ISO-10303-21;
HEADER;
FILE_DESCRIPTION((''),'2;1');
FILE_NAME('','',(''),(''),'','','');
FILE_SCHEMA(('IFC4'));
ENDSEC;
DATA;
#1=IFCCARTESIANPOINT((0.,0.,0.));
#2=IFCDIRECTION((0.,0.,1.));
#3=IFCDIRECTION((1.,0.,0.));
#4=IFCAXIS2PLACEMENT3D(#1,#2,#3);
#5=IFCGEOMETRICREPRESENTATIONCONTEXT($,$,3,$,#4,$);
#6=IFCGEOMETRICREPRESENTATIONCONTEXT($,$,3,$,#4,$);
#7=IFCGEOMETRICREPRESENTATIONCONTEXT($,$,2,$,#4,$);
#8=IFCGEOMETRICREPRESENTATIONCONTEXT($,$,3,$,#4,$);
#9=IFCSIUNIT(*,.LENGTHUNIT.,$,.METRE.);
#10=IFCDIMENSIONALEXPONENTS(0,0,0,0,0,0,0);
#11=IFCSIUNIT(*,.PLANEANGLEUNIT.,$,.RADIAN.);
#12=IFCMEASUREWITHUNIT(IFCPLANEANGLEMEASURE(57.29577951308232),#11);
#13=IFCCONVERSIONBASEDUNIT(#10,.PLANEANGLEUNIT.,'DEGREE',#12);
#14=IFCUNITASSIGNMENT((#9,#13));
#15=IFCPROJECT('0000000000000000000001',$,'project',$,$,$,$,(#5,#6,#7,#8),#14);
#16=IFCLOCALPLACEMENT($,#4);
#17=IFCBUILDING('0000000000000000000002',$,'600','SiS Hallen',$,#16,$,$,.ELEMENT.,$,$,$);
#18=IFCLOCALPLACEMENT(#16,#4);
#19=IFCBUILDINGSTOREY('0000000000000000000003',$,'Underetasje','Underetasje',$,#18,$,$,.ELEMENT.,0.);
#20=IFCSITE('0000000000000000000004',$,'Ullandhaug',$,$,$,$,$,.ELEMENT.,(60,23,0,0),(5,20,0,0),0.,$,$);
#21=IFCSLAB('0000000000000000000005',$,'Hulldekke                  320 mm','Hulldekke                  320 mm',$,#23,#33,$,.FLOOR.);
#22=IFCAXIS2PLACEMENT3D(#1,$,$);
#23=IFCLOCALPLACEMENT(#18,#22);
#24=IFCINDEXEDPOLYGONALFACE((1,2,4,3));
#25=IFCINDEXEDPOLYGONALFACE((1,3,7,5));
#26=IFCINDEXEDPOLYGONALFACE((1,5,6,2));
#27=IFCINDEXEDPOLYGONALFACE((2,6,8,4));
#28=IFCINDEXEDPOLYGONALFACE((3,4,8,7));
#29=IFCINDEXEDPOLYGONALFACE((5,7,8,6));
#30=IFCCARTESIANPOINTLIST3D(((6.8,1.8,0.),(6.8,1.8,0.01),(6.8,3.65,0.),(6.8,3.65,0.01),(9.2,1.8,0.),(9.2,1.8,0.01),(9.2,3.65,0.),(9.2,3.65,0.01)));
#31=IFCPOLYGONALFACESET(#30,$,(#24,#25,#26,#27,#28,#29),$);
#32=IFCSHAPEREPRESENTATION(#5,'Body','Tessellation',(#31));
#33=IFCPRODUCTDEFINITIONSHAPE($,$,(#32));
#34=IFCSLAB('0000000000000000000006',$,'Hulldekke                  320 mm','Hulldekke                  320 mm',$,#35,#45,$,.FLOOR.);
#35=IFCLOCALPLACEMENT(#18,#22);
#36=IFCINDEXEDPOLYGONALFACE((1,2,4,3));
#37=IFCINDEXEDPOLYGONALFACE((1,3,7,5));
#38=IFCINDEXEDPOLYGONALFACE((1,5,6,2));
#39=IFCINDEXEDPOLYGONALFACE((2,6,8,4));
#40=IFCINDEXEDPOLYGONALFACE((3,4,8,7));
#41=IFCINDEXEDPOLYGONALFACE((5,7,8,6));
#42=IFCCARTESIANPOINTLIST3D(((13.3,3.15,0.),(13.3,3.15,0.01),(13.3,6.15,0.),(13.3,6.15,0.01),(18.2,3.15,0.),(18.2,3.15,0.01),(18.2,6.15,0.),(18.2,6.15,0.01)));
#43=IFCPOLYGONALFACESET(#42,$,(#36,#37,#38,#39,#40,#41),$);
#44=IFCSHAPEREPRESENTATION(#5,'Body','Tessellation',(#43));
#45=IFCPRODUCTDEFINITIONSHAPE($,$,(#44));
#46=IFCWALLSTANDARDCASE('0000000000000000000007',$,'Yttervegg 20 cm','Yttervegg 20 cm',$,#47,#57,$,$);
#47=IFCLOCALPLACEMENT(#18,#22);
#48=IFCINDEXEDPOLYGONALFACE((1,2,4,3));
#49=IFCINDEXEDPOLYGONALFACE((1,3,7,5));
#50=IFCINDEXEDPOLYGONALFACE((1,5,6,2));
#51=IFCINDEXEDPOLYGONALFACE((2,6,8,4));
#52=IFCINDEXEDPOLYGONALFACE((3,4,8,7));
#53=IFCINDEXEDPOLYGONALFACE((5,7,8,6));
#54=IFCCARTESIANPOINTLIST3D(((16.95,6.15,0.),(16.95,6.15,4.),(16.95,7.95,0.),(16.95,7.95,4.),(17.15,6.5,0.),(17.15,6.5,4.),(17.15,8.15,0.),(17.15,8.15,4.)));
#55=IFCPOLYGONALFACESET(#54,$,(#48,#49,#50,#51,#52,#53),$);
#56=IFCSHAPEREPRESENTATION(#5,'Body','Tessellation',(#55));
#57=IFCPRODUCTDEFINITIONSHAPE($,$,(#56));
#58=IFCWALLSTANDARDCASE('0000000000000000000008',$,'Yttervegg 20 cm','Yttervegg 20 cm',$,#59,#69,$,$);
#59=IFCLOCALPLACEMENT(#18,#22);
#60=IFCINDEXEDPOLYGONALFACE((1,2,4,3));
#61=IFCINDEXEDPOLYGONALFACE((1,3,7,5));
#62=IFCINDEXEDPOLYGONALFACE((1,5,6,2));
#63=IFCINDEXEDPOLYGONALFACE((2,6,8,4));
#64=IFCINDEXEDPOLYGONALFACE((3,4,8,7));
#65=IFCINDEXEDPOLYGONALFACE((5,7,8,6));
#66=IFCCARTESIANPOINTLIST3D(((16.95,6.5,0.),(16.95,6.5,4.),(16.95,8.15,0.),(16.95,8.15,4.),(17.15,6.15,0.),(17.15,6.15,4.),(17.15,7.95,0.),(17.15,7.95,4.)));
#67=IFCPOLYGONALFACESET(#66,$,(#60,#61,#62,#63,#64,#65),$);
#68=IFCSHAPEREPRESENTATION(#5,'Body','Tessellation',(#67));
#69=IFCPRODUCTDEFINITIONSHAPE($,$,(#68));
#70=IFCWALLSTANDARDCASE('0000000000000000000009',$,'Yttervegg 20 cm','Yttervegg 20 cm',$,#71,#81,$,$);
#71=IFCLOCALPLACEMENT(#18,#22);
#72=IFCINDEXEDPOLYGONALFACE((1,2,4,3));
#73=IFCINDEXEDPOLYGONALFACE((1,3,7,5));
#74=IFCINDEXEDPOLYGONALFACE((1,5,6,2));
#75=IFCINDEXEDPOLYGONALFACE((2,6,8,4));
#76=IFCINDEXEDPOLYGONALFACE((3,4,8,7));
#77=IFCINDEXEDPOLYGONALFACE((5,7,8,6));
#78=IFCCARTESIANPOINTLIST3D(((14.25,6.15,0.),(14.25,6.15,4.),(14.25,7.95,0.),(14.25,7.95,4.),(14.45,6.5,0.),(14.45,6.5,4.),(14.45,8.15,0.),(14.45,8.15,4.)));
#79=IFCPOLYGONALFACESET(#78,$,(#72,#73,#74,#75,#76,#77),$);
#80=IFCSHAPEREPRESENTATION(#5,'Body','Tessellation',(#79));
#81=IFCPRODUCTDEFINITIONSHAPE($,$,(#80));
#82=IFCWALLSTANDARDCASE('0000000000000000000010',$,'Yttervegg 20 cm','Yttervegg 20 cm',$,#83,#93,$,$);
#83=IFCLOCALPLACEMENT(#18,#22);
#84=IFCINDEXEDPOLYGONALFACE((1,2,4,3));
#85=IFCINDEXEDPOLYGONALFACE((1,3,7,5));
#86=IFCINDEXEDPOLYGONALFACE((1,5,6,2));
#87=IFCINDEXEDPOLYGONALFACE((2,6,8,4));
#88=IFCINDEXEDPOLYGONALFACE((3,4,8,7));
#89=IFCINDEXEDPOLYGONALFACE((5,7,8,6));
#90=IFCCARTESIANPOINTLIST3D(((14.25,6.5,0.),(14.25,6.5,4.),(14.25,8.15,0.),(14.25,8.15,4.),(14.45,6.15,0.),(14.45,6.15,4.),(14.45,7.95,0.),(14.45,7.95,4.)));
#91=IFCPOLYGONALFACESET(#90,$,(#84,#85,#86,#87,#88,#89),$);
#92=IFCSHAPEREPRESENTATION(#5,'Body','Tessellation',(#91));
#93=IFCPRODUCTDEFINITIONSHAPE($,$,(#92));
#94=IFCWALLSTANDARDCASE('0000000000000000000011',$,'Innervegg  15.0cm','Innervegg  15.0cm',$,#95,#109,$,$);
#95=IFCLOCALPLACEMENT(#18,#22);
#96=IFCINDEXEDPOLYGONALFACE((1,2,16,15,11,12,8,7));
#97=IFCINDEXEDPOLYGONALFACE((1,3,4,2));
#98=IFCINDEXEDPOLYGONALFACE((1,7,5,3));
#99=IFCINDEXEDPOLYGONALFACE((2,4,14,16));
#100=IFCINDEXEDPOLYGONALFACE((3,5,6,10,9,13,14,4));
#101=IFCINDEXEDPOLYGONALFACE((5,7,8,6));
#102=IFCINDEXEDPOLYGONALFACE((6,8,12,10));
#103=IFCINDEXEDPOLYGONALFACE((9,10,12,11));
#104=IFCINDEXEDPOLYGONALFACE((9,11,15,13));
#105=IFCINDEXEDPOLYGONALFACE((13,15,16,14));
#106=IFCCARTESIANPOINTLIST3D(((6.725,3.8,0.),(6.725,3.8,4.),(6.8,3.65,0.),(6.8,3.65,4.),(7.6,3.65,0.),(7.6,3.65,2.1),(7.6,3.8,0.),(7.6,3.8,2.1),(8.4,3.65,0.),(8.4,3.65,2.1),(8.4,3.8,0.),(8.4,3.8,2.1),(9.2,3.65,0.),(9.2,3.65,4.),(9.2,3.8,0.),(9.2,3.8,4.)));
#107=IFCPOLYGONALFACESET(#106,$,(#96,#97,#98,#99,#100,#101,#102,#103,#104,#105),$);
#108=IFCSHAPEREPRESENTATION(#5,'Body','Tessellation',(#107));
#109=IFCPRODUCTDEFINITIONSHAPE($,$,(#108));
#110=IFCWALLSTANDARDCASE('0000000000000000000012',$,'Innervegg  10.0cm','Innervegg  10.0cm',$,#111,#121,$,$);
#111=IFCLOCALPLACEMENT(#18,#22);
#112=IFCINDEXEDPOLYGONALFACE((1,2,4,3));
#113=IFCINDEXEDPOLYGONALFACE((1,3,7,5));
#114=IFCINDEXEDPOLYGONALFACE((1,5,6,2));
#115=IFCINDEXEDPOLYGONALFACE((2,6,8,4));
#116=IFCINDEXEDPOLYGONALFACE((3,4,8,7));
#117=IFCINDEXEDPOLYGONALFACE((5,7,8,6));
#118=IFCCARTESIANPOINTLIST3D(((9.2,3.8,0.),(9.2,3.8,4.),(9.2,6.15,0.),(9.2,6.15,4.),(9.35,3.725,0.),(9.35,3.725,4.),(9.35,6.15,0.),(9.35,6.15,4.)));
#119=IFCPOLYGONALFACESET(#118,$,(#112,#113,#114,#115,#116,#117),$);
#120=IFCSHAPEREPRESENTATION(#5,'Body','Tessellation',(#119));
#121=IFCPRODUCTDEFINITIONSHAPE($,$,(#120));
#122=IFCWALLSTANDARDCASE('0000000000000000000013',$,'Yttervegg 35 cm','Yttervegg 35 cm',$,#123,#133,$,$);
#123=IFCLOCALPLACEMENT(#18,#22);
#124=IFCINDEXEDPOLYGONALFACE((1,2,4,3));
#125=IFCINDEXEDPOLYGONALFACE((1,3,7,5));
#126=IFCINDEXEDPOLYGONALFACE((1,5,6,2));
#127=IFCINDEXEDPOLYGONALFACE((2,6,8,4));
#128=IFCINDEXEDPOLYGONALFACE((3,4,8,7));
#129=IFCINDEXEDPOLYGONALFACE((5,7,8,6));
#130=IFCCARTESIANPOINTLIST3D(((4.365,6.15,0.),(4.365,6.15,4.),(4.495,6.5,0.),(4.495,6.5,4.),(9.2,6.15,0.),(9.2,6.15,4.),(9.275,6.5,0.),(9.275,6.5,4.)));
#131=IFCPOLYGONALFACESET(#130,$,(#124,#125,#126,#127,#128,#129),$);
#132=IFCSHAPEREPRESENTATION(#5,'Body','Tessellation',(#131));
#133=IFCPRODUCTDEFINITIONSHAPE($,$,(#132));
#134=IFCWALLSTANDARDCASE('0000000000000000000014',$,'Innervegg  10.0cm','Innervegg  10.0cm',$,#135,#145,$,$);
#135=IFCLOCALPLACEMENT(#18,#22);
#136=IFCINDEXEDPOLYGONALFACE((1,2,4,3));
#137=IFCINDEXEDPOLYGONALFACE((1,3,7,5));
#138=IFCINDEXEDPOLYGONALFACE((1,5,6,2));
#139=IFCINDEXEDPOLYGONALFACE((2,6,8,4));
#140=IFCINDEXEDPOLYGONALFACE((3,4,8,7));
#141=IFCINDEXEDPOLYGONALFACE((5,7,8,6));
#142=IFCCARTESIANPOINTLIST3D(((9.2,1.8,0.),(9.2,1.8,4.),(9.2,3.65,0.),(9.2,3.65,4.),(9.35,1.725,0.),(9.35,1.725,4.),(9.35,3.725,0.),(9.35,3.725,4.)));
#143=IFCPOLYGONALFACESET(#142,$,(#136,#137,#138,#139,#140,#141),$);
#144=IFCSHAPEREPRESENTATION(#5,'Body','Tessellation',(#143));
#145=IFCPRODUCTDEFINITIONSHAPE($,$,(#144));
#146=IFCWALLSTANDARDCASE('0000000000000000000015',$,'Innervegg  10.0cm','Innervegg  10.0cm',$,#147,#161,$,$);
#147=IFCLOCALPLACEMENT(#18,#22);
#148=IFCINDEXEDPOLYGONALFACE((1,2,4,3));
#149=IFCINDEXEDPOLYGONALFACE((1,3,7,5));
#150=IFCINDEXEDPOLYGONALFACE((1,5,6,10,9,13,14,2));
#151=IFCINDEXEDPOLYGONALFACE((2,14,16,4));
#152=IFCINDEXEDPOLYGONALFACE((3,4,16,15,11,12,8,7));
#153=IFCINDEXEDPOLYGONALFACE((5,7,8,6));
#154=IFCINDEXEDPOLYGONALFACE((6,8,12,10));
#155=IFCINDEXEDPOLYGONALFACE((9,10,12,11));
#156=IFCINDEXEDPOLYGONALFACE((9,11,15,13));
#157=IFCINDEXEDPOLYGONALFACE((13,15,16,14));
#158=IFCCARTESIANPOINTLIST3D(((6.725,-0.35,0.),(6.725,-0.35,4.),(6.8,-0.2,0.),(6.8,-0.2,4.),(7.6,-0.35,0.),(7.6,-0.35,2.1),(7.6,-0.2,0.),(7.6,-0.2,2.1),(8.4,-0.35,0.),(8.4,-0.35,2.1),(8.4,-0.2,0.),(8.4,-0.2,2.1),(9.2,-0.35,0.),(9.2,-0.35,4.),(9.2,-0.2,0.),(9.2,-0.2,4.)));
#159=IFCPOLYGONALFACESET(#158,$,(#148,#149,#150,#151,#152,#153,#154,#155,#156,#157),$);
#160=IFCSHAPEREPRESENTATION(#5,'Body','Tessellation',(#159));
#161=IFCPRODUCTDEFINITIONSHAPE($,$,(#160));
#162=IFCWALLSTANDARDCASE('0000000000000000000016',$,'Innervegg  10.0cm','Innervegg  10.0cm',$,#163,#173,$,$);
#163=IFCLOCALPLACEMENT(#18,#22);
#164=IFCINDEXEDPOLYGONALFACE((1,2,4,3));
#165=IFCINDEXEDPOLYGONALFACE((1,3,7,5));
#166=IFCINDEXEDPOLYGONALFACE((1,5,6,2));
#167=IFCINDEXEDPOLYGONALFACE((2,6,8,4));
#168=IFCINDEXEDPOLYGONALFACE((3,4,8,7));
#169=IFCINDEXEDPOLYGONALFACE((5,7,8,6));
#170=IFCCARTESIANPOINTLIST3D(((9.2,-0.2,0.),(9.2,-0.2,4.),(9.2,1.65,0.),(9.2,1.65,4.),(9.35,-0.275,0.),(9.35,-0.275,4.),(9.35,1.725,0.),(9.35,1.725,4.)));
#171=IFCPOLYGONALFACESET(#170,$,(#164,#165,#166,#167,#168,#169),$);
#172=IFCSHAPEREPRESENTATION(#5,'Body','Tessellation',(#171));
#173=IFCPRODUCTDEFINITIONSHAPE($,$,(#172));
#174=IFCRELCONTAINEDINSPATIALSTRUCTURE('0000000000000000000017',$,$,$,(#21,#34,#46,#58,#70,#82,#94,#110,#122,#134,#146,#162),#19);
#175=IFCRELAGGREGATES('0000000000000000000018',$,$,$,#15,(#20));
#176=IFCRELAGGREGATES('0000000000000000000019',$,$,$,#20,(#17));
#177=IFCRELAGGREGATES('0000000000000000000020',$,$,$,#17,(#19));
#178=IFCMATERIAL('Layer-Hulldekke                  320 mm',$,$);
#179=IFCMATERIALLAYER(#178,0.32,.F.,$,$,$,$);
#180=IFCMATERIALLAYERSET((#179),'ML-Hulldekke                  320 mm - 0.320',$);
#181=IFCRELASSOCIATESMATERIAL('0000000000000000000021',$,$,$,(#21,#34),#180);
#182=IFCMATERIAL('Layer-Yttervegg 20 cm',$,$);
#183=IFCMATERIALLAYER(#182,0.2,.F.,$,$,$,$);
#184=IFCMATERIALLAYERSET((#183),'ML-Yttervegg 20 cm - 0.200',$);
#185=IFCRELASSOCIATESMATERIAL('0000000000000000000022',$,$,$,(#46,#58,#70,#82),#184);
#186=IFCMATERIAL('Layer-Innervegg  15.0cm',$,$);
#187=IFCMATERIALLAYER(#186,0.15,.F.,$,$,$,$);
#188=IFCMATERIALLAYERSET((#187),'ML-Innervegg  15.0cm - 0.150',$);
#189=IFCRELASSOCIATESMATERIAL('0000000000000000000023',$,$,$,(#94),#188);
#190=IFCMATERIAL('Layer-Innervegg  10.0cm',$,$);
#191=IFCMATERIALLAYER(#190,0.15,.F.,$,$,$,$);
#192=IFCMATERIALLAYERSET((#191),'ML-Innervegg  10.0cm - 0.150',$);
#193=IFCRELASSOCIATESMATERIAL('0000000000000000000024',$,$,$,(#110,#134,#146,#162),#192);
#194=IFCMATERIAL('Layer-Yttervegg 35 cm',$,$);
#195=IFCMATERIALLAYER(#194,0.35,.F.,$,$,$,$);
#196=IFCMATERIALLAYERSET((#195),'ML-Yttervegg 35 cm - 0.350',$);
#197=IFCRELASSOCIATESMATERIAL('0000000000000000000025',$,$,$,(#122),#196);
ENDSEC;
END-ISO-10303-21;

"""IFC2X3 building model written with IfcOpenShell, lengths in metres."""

from ifc_helpers import new_model, entity, si_unit, converted_unit, frame, origin_with_axes, place, context, project, spatial, polyline, outline, extrude, material, layer, layer_set, layer_usage, element, save


model = new_model("IFC2X3")

# Units and contexts
context_of_model_1 = context(None, 3, world=origin_with_axes())
context_of_model_2 = context(None, 3, world=origin_with_axes())
context_of_model_3 = context(None, 2, world=origin_with_axes())
context_of_model_4 = context(None, 3, world=origin_with_axes())
ifc_project = project(units=[si_unit("LENGTHUNIT", "METRE"), converted_unit("PLANEANGLEUNIT", "DEGREE", entity("IfcPlaneAngleMeasure", 57.29577951308232), si_unit("PLANEANGLEUNIT", "RADIAN"), dimensions=[0, 0, 0, 0, 0, 0, 0])], contexts=[context_of_model_1, context_of_model_2, context_of_model_3, context_of_model_4])

# Site, building, storey
site = spatial("IfcSite", under=ifc_project, Name="Ullandhaug", CompositionType="ELEMENT", RefLatitude=(60, 23, 0, 0), RefLongitude=(5, 20, 0, 0), RefElevation=0.0)
building_placement = place(None, origin_with_axes())
building = spatial("IfcBuilding", under=site, at=building_placement, Name="600", Description="SiS Hallen", CompositionType="ELEMENT")
storey_placement = place(building_placement, origin_with_axes())
storey = spatial("IfcBuildingStorey", under=building, at=storey_placement, Name="Underetasje", Description="Underetasje", CompositionType="ELEMENT", Elevation=0.0)

# Slabs
ifc_material_1 = material(Name="Layer-Hulldekke                  320 mm")
ifc_layer_1 = layer(ifc_material_1, 0.32, ventilated=False)
ifc_layer_set_1 = layer_set([ifc_layer_1], Name="ML-Hulldekke                  320 mm - 0.320")
ifc_layer_usage_1 = layer_usage(ifc_layer_set_1, "AXIS2", "POSITIVE", 0.0)
slab_1_placement = place(storey_placement, frame((6.8, 1.8, 0.0), z_axis=(0.0, 0.0, 1.0), x_axis=(1.0, 0.0, 0.0)))
element("IfcSlab", 1, at=slab_1_placement, inside=storey, material=ifc_layer_usage_1, Name="Hulldekke                  320 mm", Description="Hulldekke                  320 mm", PredefinedType="FLOOR", context=context_of_model_1, shape_type="SweptSolid", body=[
    extrude(outline(polyline([(0.0, 0.0), (2.4, 0.0), (2.4, 1.85), (0.0, 1.85), (0.0, 0.0)])), origin_with_axes(), (0.0, 0.0, 1.0), 0.01),
])
slab_2_placement = place(storey_placement, frame((13.3, 3.15, 0.0), z_axis=(0.0, 0.0, 1.0), x_axis=(1.0, 0.0, 0.0)))
element("IfcSlab", 2, at=slab_2_placement, inside=storey, material=ifc_layer_usage_1, Name="Hulldekke                  320 mm", Description="Hulldekke                  320 mm", PredefinedType="FLOOR", context=context_of_model_1, shape_type="SweptSolid", body=[
    extrude(outline(polyline([(0.0, 0.0), (4.9, 0.0), (4.9, 3.0), (0.0, 3.0), (0.0, 0.0)])), origin_with_axes(), (0.0, 0.0, 1.0), 0.01),
])

# Walls
ifc_material_2 = material(Name="Layer-Yttervegg 20 cm")
ifc_layer_2 = layer(ifc_material_2, 0.2, ventilated=False)
ifc_layer_set_2 = layer_set([ifc_layer_2], Name="ML-Yttervegg 20 cm - 0.200")
ifc_layer_usage_2 = layer_usage(ifc_layer_set_2, "AXIS2", "POSITIVE", 0.0)
wall_1_placement = place(storey_placement, frame((17.15, 6.5, 0.0), z_axis=(0.0, 0.0, 1.0), x_axis=(0.0, 1.0, 0.0)))
element("IfcWallStandardCase", 3, at=wall_1_placement, inside=storey, material=ifc_layer_usage_2, Name="Yttervegg 20 cm", Description="Yttervegg 20 cm", context=context_of_model_1, shape_type="SweptSolid", body=[
    extrude(outline(polyline([(0.0, 0.0), (1.65, 0.0), (1.45, 0.2), (-0.35, 0.2), (0.0, 0.0)])), frame((0.0, 0.0, 0.0), z_axis=(0.0, 0.0, 1.0), x_axis=(1.0, 0.0, 0.0)), (0.0, 0.0, 1.0), 4.0),
])
wall_2_placement = place(storey_placement, frame((16.95, 8.15, 0.0), z_axis=(0.0, 0.0, 1.0), x_axis=(0.0, -1.0, 0.0)))
element("IfcWallStandardCase", 4, at=wall_2_placement, inside=storey, material=ifc_layer_usage_2, Name="Yttervegg 20 cm", Description="Yttervegg 20 cm", context=context_of_model_1, shape_type="SweptSolid", body=[
    extrude(outline(polyline([(0.0, 0.0), (1.65, 0.0), (2.0, 0.2), (0.2, 0.2), (0.0, 0.0)])), frame((0.0, 0.0, 0.0), z_axis=(0.0, 0.0, 1.0), x_axis=(1.0, 0.0, 0.0)), (0.0, 0.0, 1.0), 4.0),
])
wall_3_placement = place(storey_placement, frame((14.45, 6.5, 0.0), z_axis=(0.0, 0.0, 1.0), x_axis=(0.0, 1.0, 0.0)))
element("IfcWallStandardCase", 5, at=wall_3_placement, inside=storey, material=ifc_layer_usage_2, Name="Yttervegg 20 cm", Description="Yttervegg 20 cm", context=context_of_model_1, shape_type="SweptSolid", body=[
    extrude(outline(polyline([(0.0, 0.0), (1.65, 0.0), (1.45, 0.2), (-0.35, 0.2), (0.0, 0.0)])), frame((0.0, 0.0, 0.0), z_axis=(0.0, 0.0, 1.0), x_axis=(1.0, 0.0, 0.0)), (0.0, 0.0, 1.0), 4.0),
])
wall_4_placement = place(storey_placement, frame((14.25, 8.15, 0.0), z_axis=(0.0, 0.0, 1.0), x_axis=(0.0, -1.0, 0.0)))
element("IfcWallStandardCase", 6, at=wall_4_placement, inside=storey, material=ifc_layer_usage_2, Name="Yttervegg 20 cm", Description="Yttervegg 20 cm", context=context_of_model_1, shape_type="SweptSolid", body=[
    extrude(outline(polyline([(0.0, 0.0), (1.65, 0.0), (2.0, 0.2), (0.2, 0.2), (0.0, 0.0)])), frame((0.0, 0.0, 0.0), z_axis=(0.0, 0.0, 1.0), x_axis=(1.0, 0.0, 0.0)), (0.0, 0.0, 1.0), 4.0),
])

# Wall, opening
ifc_material_3 = material(Name="Layer-Innervegg  15.0cm")
ifc_layer_3 = layer(ifc_material_3, 0.15, ventilated=False)
ifc_layer_set_3 = layer_set([ifc_layer_3], Name="ML-Innervegg  15.0cm - 0.150")
ifc_layer_usage_3 = layer_usage(ifc_layer_set_3, "AXIS2", "POSITIVE", 0.0)
wall_5_placement = place(storey_placement, frame((6.8, 3.65, 0.0), z_axis=(0.0, 0.0, 1.0), x_axis=(1.0, 0.0, 0.0)))
wall_5 = element("IfcWallStandardCase", 7, at=wall_5_placement, inside=storey, material=ifc_layer_usage_3, Name="Innervegg  15.0cm", Description="Innervegg  15.0cm", context=context_of_model_1, shape_type="SweptSolid", body=[
    extrude(outline(polyline([(0.0, 0.0), (2.4, 0.0), (2.4, 0.15), (-0.075, 0.15), (0.0, 0.0)])), origin_with_axes(), (0.0, 0.0, 1.0), 4.0),
])
opening_1_placement = place(wall_5_placement, frame((0.8, 0.15, 0.0), z_axis=(0.0, 0.0, 1.0), x_axis=(1.0, 0.0, 0.0)))
element("IfcOpeningElement", 8, at=opening_1_placement, cuts=wall_5, context=context_of_model_1, shape_type="SweptSolid", body=[
    extrude(outline(polyline([(0.0, 0.0), (2.1, 0.0), (2.1, 0.8), (0.0, 0.8), (0.0, 0.0)])), frame((0.0, 0.0, 0.0), z_axis=(0.0, 1.0, 0.0), x_axis=(0.0, 0.0, 1.0)), (0.0, 0.0, -1.0), 0.15),
])

# Walls
ifc_material_4 = material(Name="Layer-Innervegg  10.0cm")
ifc_layer_4 = layer(ifc_material_4, 0.15, ventilated=False)
ifc_layer_set_4 = layer_set([ifc_layer_4], Name="ML-Innervegg  10.0cm - 0.150")
ifc_layer_usage_4 = layer_usage(ifc_layer_set_4, "AXIS2", "POSITIVE", 0.0)
wall_6_placement = place(storey_placement, frame((9.35, 3.725, 0.0), z_axis=(0.0, 0.0, 1.0), x_axis=(0.0, 1.0, 0.0)))
element("IfcWallStandardCase", 9, at=wall_6_placement, inside=storey, material=ifc_layer_usage_4, Name="Innervegg  10.0cm", Description="Innervegg  10.0cm", context=context_of_model_1, shape_type="SweptSolid", body=[
    extrude(outline(polyline([(0.0, 0.0), (2.425, 0.0), (2.425, 0.15), (0.075, 0.15), (0.0, 0.0)])), frame((0.0, 0.0, 0.0), z_axis=(0.0, 0.0, 1.0), x_axis=(1.0, 0.0, 0.0)), (0.0, 0.0, 1.0), 4.0),
])
ifc_material_5 = material(Name="Layer-Yttervegg 35 cm")
ifc_layer_5 = layer(ifc_material_5, 0.35, ventilated=False)
ifc_layer_set_5 = layer_set([ifc_layer_5], Name="ML-Yttervegg 35 cm - 0.350")
ifc_layer_usage_5 = layer_usage(ifc_layer_set_5, "AXIS2", "POSITIVE", 0.0)
wall_7_placement = place(storey_placement, frame((9.275, 6.5, 0.0), z_axis=(0.0, 0.0, 1.0), x_axis=(-1.0, 0.0, 0.0)))
element("IfcWallStandardCase", 10, at=wall_7_placement, inside=storey, material=ifc_layer_usage_5, Name="Yttervegg 35 cm", Description="Yttervegg 35 cm", context=context_of_model_1, shape_type="SweptSolid", body=[
    extrude(outline(polyline([(0.0, 0.0), (4.78, 0.0), (4.91, 0.35), (0.075, 0.35), (0.0, 0.0)])), frame((0.0, 0.0, 0.0), z_axis=(0.0, 0.0, 1.0), x_axis=(1.0, 0.0, 0.0)), (0.0, 0.0, 1.0), 4.0),
])
wall_8_placement = place(storey_placement, frame((9.35, 1.725, 0.0), z_axis=(0.0, 0.0, 1.0), x_axis=(0.0, 1.0, 0.0)))
element("IfcWallStandardCase", 11, at=wall_8_placement, inside=storey, material=ifc_layer_usage_4, Name="Innervegg  10.0cm", Description="Innervegg  10.0cm", context=context_of_model_1, shape_type="SweptSolid", body=[
    extrude(outline(polyline([(0.0, 0.0), (2.0, 0.0), (1.925, 0.15), (0.075, 0.15), (0.0, 0.0)])), frame((0.0, 0.0, 0.0), z_axis=(0.0, 0.0, 1.0), x_axis=(1.0, 0.0, 0.0)), (0.0, 0.0, 1.0), 4.0),
])

# Wall, opening
wall_9_placement = place(storey_placement, frame((9.2, -0.2, 0.0), z_axis=(0.0, 0.0, 1.0), x_axis=(-1.0, 0.0, 0.0)))
wall_9 = element("IfcWallStandardCase", 12, at=wall_9_placement, inside=storey, material=ifc_layer_usage_4, Name="Innervegg  10.0cm", Description="Innervegg  10.0cm", context=context_of_model_1, shape_type="SweptSolid", body=[
    extrude(outline(polyline([(0.0, 0.0), (2.4, 0.0), (2.475, 0.15), (0.0, 0.15), (0.0, 0.0)])), frame((0.0, 0.0, 0.0), z_axis=(0.0, 0.0, 1.0), x_axis=(1.0, 0.0, 0.0)), (0.0, 0.0, 1.0), 4.0),
])
opening_2_placement = place(wall_9_placement, frame((0.8, 0.15, 0.0), z_axis=(0.0, 0.0, 1.0), x_axis=(1.0, 0.0, 0.0)))
element("IfcOpeningElement", 13, at=opening_2_placement, cuts=wall_9, context=context_of_model_1, shape_type="SweptSolid", body=[
    extrude(outline(polyline([(0.0, 0.0), (2.1, 0.0), (2.1, 0.8), (0.0, 0.8), (0.0, 0.0)])), frame((0.0, 0.0, 0.0), z_axis=(0.0, 1.0, 0.0), x_axis=(0.0, 0.0, 1.0)), (0.0, 0.0, -1.0), 0.15),
])

# Wall
wall_10_placement = place(storey_placement, frame((9.35, -0.275, 0.0), z_axis=(0.0, 0.0, 1.0), x_axis=(0.0, 1.0, 0.0)))
element("IfcWallStandardCase", 14, at=wall_10_placement, inside=storey, material=ifc_layer_usage_4, Name="Innervegg  10.0cm", Description="Innervegg  10.0cm", context=context_of_model_1, shape_type="SweptSolid", body=[
    extrude(outline(polyline([(0.0, 0.0), (2.0, 0.0), (1.925, 0.15), (0.075, 0.15), (0.0, 0.0)])), frame((0.0, 0.0, 0.0), z_axis=(0.0, 0.0, 1.0), x_axis=(1.0, 0.0, 0.0)), (0.0, 0.0, 1.0), 4.0),
])

save(model, "model.ifc")
